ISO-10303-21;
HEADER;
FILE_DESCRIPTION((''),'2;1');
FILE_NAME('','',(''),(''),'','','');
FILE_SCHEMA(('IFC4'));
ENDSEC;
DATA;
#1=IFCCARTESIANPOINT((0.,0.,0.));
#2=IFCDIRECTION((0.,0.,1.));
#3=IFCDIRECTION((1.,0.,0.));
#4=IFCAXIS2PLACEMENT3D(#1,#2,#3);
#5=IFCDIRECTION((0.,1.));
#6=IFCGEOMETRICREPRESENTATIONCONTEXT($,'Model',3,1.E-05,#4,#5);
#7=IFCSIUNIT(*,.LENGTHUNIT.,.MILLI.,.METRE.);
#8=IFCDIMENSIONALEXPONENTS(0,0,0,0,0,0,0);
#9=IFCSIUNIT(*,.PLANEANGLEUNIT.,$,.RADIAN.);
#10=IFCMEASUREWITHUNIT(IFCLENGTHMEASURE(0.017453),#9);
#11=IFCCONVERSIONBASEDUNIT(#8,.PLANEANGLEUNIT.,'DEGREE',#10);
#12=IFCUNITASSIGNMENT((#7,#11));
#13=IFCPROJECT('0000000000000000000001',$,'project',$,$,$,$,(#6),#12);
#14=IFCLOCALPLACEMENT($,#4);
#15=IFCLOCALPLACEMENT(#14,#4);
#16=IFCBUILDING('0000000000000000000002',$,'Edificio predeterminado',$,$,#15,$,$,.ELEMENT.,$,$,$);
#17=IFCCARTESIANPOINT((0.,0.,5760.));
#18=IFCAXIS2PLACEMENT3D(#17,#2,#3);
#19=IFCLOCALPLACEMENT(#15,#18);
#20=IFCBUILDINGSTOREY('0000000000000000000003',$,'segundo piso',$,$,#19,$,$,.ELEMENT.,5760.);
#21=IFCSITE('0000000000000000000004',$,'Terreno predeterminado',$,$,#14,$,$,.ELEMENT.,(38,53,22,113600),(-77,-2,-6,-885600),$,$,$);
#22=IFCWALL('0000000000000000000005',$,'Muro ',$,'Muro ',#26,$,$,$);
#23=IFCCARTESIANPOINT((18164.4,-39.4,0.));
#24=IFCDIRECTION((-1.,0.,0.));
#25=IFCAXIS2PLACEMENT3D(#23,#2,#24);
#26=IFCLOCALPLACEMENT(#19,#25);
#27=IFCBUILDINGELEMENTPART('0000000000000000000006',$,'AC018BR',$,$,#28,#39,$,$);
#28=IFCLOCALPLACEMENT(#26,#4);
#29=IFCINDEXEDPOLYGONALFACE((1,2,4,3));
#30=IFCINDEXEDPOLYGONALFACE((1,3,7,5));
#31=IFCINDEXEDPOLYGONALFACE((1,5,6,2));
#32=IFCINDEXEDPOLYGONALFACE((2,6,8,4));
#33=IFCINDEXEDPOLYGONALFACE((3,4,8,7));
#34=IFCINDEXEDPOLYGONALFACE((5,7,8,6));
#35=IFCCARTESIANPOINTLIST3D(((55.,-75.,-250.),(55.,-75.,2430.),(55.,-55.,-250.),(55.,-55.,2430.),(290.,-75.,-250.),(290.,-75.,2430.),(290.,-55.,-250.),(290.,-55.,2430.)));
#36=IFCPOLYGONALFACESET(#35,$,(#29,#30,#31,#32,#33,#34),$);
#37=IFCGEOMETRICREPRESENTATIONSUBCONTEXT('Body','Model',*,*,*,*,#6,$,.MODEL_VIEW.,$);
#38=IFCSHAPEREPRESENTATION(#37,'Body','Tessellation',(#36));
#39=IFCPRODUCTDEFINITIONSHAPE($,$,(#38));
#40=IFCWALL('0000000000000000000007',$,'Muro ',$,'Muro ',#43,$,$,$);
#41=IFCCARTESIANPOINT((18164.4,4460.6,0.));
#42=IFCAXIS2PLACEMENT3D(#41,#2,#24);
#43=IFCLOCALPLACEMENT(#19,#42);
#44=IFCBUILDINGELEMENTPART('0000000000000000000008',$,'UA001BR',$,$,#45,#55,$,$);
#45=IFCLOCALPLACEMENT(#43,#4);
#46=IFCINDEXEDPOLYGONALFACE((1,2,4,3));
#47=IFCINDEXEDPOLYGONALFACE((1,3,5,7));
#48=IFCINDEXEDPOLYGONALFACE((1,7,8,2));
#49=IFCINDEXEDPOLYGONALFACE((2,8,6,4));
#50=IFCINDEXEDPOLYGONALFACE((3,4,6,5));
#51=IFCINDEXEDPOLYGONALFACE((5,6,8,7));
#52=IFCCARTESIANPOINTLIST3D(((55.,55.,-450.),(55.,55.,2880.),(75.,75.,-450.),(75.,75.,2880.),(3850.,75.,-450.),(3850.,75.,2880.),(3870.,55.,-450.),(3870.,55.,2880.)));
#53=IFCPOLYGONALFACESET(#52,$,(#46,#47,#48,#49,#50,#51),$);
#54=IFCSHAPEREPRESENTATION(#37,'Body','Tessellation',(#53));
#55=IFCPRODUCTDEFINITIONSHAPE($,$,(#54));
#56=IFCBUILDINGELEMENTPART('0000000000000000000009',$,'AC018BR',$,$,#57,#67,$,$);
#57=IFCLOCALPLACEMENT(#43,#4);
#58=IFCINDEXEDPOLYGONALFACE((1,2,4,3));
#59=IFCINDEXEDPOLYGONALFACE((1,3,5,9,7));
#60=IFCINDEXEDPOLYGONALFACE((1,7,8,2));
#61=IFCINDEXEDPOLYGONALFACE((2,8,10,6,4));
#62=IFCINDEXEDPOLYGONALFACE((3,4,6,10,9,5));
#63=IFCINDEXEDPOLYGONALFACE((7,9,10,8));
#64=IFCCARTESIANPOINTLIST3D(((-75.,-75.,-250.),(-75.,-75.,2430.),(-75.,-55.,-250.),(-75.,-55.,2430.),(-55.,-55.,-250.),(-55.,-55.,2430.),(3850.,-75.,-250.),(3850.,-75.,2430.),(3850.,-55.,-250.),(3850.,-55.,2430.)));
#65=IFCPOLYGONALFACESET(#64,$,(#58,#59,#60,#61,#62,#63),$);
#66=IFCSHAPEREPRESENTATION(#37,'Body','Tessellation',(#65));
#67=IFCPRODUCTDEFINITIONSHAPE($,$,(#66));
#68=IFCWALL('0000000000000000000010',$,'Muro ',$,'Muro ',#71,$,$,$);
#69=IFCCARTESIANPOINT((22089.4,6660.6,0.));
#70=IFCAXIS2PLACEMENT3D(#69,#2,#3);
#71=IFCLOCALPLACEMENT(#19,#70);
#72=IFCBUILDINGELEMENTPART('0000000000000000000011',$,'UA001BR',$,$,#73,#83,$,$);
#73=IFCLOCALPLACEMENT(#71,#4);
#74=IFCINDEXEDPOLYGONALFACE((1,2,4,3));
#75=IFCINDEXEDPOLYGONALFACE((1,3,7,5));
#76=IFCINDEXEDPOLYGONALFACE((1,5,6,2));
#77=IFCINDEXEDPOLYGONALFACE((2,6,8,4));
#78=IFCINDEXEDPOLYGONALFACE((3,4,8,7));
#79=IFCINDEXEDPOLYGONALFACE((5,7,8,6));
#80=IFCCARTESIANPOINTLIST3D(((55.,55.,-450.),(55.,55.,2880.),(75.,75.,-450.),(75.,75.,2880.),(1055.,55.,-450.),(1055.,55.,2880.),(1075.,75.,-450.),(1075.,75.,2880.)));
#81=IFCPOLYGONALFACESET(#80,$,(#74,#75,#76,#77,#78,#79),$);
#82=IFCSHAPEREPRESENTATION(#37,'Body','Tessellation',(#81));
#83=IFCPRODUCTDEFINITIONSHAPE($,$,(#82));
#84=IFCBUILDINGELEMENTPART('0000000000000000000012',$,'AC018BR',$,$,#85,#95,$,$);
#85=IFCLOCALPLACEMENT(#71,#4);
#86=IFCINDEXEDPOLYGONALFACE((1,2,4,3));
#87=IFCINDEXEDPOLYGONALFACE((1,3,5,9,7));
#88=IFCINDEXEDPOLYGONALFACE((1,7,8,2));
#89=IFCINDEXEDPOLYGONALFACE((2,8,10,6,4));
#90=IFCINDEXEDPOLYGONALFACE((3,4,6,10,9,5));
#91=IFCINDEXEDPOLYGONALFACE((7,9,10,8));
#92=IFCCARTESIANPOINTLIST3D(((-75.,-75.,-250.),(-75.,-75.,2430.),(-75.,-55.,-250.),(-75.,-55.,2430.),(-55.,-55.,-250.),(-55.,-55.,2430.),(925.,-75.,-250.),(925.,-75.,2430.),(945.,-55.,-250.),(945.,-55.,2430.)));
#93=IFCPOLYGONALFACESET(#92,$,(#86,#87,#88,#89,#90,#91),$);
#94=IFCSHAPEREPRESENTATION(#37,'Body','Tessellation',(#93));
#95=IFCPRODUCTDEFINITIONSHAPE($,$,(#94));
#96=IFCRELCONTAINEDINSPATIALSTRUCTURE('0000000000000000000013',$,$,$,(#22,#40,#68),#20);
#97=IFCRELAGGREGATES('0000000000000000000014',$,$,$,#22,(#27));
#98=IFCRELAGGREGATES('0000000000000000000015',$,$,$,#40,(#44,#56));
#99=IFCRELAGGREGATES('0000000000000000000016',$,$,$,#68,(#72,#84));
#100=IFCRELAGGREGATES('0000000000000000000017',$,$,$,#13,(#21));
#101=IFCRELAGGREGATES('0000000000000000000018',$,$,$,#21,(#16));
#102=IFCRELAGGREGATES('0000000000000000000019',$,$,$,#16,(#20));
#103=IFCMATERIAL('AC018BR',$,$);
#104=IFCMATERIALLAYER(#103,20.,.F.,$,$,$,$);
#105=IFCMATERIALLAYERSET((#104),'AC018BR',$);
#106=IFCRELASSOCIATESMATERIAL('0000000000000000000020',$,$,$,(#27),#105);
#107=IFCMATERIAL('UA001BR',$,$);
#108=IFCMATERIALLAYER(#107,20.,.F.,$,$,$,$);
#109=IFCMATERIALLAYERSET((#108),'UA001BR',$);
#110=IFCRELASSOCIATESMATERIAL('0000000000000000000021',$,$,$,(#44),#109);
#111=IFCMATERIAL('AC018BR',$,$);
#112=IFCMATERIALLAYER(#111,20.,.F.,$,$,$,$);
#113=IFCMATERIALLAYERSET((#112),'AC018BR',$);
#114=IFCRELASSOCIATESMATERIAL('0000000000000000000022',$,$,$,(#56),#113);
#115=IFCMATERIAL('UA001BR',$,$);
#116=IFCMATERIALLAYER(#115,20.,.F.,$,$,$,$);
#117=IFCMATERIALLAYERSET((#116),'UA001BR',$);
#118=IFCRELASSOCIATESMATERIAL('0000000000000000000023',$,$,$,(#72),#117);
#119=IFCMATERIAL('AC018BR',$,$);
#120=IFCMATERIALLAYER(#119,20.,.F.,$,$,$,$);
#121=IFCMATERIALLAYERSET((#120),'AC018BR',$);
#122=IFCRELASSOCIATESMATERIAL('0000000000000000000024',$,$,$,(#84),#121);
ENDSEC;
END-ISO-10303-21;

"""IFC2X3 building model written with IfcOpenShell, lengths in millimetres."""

from ifc_helpers import new_model, entity, si_unit, converted_unit, direction, frame, origin_with_axes, place, context, subcontext, project, spatial, polyline, outline, extrude, material, layer, layer_set, layer_usage, element, aggregate, save


model = new_model("IFC2X3")

# Units and contexts
model_context = context("Model", 3, precision=1e-05, world=origin_with_axes(), true_north=direction((0.0, 1.0)))
body_context = subcontext(model_context, "Body", "Model", "MODEL_VIEW")
ifc_project = project(units=[si_unit("LENGTHUNIT", "METRE", prefix="MILLI"), converted_unit("PLANEANGLEUNIT", "DEGREE", entity("IfcLengthMeasure", 0.017453), si_unit("PLANEANGLEUNIT", "RADIAN"), dimensions=[0, 0, 0, 0, 0, 0, 0])], contexts=[model_context])

# Site, building, storey
site_placement = place(None, origin_with_axes())
site = spatial("IfcSite", under=ifc_project, at=site_placement, Name="Terreno predeterminado", CompositionType="ELEMENT", RefLatitude=(38, 53, 22, 113600), RefLongitude=(-77, -2, -6, -885600))
building_placement = place(site_placement, origin_with_axes())
building = spatial("IfcBuilding", under=site, at=building_placement, Name="Edificio predeterminado", CompositionType="ELEMENT")
storey_placement = place(building_placement, frame((0.0, 0.0, 5760.0), z_axis=(0.0, 0.0, 1.0), x_axis=(1.0, 0.0, 0.0)))
storey = spatial("IfcBuildingStorey", under=building, at=storey_placement, Name="segundo piso", CompositionType="ELEMENT", Elevation=5760.0)

# Wall, building element part
wall_1_placement = place(storey_placement, frame((18164.4, -39.4, 0.0), z_axis=(0.0, 0.0, 1.0), x_axis=(-1.0, 0.0, 0.0)))
wall_1 = element("IfcWall", 1, at=wall_1_placement, inside=storey, Name="Muro ", ObjectType="Muro ")
ifc_material_1 = material(Name="AC018BR")
ifc_layer_1 = layer(ifc_material_1, 20.0, ventilated=False)
ifc_layer_set_1 = layer_set([ifc_layer_1], Name="AC018BR")
ifc_layer_usage_1 = layer_usage(ifc_layer_set_1, "AXIS2", "NEGATIVE", 55.0)
building_element_part_1_placement = place(wall_1_placement, origin_with_axes())
building_element_part_1 = element("IfcBuildingElementPart", 2, at=building_element_part_1_placement, material=ifc_layer_usage_1, Name="AC018BR", context=body_context, shape_type="SweptSolid", body=[
    extrude(outline(polyline([(290.0, -55.0), (290.0, -75.0), (55.0, -75.0), (55.0, -55.0), (290.0, -55.0)])), frame((0.0, 0.0, -250.0), z_axis=(0.0, 0.0, 1.0), x_axis=(1.0, 0.0, 0.0)), (0.0, 0.0, 1.0), 2680.0),
])
aggregate(wall_1, [building_element_part_1])

# Walls, building element parts
wall_2_placement = place(storey_placement, frame((18164.4, 4460.6, 0.0), z_axis=(0.0, 0.0, 1.0), x_axis=(-1.0, 0.0, 0.0)))
wall_2 = element("IfcWall", 3, at=wall_2_placement, inside=storey, Name="Muro ", ObjectType="Muro ")
ifc_material_2 = material(Name="UA001BR")
ifc_layer_2 = layer(ifc_material_2, 20.0, ventilated=False)
ifc_layer_set_2 = layer_set([ifc_layer_2], Name="UA001BR")
ifc_layer_usage_2 = layer_usage(ifc_layer_set_2, "AXIS2", "NEGATIVE", -75.0)
building_element_part_2_placement = place(wall_2_placement, origin_with_axes())
building_element_part_2 = element("IfcBuildingElementPart", 4, at=building_element_part_2_placement, material=ifc_layer_usage_2, Name="UA001BR", context=body_context, shape_type="SweptSolid", body=[
    extrude(outline(polyline([(3850.0, 75.0), (3870.0, 55.0), (55.0, 55.0), (75.0, 75.0), (3850.0, 75.0)])), frame((0.0, 0.0, -450.0), z_axis=(0.0, 0.0, 1.0), x_axis=(1.0, 0.0, 0.0)), (0.0, 0.0, 1.0), 3330.0),
])
ifc_material_3 = material(Name="AC018BR")
ifc_layer_3 = layer(ifc_material_3, 20.0, ventilated=False)
ifc_layer_set_3 = layer_set([ifc_layer_3], Name="AC018BR")
ifc_layer_usage_3 = layer_usage(ifc_layer_set_3, "AXIS2", "NEGATIVE", 55.0)
building_element_part_3_placement = place(wall_2_placement, origin_with_axes())
building_element_part_3 = element("IfcBuildingElementPart", 5, at=building_element_part_3_placement, material=ifc_layer_usage_3, Name="AC018BR", context=body_context, shape_type="SweptSolid", body=[
    extrude(outline(polyline([(3850.0, -55.0), (3850.0, -75.0), (-75.0, -75.0), (-75.0, -55.0), (-55.0, -55.0), (3850.0, -55.0)])), frame((0.0, 0.0, -250.0), z_axis=(0.0, 0.0, 1.0), x_axis=(1.0, 0.0, 0.0)), (0.0, 0.0, 1.0), 2680.0),
])
aggregate(wall_2, [building_element_part_2, building_element_part_3])
wall_3_placement = place(storey_placement, frame((22089.4, 6660.6, 0.0), z_axis=(0.0, 0.0, 1.0), x_axis=(1.0, 0.0, 0.0)))
wall_3 = element("IfcWall", 6, at=wall_3_placement, inside=storey, Name="Muro ", ObjectType="Muro ")
ifc_material_4 = material(Name="UA001BR")
ifc_layer_4 = layer(ifc_material_4, 20.0, ventilated=False)
ifc_layer_set_4 = layer_set([ifc_layer_4], Name="UA001BR")
ifc_layer_usage_4 = layer_usage(ifc_layer_set_4, "AXIS2", "NEGATIVE", -75.0)
building_element_part_4_placement = place(wall_3_placement, origin_with_axes())
building_element_part_4 = element("IfcBuildingElementPart", 7, at=building_element_part_4_placement, material=ifc_layer_usage_4, Name="UA001BR", context=body_context, shape_type="SweptSolid", body=[
    extrude(outline(polyline([(1075.0, 75.0), (1055.0, 55.0), (55.0, 55.0), (75.0, 75.0), (1075.0, 75.0)])), frame((0.0, 0.0, -450.0), z_axis=(0.0, 0.0, 1.0), x_axis=(1.0, 0.0, 0.0)), (0.0, 0.0, 1.0), 3330.0),
])
ifc_material_5 = material(Name="AC018BR")
ifc_layer_5 = layer(ifc_material_5, 20.0, ventilated=False)
ifc_layer_set_5 = layer_set([ifc_layer_5], Name="AC018BR")
ifc_layer_usage_5 = layer_usage(ifc_layer_set_5, "AXIS2", "NEGATIVE", 55.0)
building_element_part_5_placement = place(wall_3_placement, origin_with_axes())
building_element_part_5 = element("IfcBuildingElementPart", 8, at=building_element_part_5_placement, material=ifc_layer_usage_5, Name="AC018BR", context=body_context, shape_type="SweptSolid", body=[
    extrude(outline(polyline([(945.0, -55.0), (925.0, -75.0), (-75.0, -75.0), (-75.0, -55.0), (-55.0, -55.0), (945.0, -55.0)])), frame((0.0, 0.0, -250.0), z_axis=(0.0, 0.0, 1.0), x_axis=(1.0, 0.0, 0.0)), (0.0, 0.0, 1.0), 2680.0),
])
aggregate(wall_3, [building_element_part_4, building_element_part_5])

save(model, "model.ifc")
